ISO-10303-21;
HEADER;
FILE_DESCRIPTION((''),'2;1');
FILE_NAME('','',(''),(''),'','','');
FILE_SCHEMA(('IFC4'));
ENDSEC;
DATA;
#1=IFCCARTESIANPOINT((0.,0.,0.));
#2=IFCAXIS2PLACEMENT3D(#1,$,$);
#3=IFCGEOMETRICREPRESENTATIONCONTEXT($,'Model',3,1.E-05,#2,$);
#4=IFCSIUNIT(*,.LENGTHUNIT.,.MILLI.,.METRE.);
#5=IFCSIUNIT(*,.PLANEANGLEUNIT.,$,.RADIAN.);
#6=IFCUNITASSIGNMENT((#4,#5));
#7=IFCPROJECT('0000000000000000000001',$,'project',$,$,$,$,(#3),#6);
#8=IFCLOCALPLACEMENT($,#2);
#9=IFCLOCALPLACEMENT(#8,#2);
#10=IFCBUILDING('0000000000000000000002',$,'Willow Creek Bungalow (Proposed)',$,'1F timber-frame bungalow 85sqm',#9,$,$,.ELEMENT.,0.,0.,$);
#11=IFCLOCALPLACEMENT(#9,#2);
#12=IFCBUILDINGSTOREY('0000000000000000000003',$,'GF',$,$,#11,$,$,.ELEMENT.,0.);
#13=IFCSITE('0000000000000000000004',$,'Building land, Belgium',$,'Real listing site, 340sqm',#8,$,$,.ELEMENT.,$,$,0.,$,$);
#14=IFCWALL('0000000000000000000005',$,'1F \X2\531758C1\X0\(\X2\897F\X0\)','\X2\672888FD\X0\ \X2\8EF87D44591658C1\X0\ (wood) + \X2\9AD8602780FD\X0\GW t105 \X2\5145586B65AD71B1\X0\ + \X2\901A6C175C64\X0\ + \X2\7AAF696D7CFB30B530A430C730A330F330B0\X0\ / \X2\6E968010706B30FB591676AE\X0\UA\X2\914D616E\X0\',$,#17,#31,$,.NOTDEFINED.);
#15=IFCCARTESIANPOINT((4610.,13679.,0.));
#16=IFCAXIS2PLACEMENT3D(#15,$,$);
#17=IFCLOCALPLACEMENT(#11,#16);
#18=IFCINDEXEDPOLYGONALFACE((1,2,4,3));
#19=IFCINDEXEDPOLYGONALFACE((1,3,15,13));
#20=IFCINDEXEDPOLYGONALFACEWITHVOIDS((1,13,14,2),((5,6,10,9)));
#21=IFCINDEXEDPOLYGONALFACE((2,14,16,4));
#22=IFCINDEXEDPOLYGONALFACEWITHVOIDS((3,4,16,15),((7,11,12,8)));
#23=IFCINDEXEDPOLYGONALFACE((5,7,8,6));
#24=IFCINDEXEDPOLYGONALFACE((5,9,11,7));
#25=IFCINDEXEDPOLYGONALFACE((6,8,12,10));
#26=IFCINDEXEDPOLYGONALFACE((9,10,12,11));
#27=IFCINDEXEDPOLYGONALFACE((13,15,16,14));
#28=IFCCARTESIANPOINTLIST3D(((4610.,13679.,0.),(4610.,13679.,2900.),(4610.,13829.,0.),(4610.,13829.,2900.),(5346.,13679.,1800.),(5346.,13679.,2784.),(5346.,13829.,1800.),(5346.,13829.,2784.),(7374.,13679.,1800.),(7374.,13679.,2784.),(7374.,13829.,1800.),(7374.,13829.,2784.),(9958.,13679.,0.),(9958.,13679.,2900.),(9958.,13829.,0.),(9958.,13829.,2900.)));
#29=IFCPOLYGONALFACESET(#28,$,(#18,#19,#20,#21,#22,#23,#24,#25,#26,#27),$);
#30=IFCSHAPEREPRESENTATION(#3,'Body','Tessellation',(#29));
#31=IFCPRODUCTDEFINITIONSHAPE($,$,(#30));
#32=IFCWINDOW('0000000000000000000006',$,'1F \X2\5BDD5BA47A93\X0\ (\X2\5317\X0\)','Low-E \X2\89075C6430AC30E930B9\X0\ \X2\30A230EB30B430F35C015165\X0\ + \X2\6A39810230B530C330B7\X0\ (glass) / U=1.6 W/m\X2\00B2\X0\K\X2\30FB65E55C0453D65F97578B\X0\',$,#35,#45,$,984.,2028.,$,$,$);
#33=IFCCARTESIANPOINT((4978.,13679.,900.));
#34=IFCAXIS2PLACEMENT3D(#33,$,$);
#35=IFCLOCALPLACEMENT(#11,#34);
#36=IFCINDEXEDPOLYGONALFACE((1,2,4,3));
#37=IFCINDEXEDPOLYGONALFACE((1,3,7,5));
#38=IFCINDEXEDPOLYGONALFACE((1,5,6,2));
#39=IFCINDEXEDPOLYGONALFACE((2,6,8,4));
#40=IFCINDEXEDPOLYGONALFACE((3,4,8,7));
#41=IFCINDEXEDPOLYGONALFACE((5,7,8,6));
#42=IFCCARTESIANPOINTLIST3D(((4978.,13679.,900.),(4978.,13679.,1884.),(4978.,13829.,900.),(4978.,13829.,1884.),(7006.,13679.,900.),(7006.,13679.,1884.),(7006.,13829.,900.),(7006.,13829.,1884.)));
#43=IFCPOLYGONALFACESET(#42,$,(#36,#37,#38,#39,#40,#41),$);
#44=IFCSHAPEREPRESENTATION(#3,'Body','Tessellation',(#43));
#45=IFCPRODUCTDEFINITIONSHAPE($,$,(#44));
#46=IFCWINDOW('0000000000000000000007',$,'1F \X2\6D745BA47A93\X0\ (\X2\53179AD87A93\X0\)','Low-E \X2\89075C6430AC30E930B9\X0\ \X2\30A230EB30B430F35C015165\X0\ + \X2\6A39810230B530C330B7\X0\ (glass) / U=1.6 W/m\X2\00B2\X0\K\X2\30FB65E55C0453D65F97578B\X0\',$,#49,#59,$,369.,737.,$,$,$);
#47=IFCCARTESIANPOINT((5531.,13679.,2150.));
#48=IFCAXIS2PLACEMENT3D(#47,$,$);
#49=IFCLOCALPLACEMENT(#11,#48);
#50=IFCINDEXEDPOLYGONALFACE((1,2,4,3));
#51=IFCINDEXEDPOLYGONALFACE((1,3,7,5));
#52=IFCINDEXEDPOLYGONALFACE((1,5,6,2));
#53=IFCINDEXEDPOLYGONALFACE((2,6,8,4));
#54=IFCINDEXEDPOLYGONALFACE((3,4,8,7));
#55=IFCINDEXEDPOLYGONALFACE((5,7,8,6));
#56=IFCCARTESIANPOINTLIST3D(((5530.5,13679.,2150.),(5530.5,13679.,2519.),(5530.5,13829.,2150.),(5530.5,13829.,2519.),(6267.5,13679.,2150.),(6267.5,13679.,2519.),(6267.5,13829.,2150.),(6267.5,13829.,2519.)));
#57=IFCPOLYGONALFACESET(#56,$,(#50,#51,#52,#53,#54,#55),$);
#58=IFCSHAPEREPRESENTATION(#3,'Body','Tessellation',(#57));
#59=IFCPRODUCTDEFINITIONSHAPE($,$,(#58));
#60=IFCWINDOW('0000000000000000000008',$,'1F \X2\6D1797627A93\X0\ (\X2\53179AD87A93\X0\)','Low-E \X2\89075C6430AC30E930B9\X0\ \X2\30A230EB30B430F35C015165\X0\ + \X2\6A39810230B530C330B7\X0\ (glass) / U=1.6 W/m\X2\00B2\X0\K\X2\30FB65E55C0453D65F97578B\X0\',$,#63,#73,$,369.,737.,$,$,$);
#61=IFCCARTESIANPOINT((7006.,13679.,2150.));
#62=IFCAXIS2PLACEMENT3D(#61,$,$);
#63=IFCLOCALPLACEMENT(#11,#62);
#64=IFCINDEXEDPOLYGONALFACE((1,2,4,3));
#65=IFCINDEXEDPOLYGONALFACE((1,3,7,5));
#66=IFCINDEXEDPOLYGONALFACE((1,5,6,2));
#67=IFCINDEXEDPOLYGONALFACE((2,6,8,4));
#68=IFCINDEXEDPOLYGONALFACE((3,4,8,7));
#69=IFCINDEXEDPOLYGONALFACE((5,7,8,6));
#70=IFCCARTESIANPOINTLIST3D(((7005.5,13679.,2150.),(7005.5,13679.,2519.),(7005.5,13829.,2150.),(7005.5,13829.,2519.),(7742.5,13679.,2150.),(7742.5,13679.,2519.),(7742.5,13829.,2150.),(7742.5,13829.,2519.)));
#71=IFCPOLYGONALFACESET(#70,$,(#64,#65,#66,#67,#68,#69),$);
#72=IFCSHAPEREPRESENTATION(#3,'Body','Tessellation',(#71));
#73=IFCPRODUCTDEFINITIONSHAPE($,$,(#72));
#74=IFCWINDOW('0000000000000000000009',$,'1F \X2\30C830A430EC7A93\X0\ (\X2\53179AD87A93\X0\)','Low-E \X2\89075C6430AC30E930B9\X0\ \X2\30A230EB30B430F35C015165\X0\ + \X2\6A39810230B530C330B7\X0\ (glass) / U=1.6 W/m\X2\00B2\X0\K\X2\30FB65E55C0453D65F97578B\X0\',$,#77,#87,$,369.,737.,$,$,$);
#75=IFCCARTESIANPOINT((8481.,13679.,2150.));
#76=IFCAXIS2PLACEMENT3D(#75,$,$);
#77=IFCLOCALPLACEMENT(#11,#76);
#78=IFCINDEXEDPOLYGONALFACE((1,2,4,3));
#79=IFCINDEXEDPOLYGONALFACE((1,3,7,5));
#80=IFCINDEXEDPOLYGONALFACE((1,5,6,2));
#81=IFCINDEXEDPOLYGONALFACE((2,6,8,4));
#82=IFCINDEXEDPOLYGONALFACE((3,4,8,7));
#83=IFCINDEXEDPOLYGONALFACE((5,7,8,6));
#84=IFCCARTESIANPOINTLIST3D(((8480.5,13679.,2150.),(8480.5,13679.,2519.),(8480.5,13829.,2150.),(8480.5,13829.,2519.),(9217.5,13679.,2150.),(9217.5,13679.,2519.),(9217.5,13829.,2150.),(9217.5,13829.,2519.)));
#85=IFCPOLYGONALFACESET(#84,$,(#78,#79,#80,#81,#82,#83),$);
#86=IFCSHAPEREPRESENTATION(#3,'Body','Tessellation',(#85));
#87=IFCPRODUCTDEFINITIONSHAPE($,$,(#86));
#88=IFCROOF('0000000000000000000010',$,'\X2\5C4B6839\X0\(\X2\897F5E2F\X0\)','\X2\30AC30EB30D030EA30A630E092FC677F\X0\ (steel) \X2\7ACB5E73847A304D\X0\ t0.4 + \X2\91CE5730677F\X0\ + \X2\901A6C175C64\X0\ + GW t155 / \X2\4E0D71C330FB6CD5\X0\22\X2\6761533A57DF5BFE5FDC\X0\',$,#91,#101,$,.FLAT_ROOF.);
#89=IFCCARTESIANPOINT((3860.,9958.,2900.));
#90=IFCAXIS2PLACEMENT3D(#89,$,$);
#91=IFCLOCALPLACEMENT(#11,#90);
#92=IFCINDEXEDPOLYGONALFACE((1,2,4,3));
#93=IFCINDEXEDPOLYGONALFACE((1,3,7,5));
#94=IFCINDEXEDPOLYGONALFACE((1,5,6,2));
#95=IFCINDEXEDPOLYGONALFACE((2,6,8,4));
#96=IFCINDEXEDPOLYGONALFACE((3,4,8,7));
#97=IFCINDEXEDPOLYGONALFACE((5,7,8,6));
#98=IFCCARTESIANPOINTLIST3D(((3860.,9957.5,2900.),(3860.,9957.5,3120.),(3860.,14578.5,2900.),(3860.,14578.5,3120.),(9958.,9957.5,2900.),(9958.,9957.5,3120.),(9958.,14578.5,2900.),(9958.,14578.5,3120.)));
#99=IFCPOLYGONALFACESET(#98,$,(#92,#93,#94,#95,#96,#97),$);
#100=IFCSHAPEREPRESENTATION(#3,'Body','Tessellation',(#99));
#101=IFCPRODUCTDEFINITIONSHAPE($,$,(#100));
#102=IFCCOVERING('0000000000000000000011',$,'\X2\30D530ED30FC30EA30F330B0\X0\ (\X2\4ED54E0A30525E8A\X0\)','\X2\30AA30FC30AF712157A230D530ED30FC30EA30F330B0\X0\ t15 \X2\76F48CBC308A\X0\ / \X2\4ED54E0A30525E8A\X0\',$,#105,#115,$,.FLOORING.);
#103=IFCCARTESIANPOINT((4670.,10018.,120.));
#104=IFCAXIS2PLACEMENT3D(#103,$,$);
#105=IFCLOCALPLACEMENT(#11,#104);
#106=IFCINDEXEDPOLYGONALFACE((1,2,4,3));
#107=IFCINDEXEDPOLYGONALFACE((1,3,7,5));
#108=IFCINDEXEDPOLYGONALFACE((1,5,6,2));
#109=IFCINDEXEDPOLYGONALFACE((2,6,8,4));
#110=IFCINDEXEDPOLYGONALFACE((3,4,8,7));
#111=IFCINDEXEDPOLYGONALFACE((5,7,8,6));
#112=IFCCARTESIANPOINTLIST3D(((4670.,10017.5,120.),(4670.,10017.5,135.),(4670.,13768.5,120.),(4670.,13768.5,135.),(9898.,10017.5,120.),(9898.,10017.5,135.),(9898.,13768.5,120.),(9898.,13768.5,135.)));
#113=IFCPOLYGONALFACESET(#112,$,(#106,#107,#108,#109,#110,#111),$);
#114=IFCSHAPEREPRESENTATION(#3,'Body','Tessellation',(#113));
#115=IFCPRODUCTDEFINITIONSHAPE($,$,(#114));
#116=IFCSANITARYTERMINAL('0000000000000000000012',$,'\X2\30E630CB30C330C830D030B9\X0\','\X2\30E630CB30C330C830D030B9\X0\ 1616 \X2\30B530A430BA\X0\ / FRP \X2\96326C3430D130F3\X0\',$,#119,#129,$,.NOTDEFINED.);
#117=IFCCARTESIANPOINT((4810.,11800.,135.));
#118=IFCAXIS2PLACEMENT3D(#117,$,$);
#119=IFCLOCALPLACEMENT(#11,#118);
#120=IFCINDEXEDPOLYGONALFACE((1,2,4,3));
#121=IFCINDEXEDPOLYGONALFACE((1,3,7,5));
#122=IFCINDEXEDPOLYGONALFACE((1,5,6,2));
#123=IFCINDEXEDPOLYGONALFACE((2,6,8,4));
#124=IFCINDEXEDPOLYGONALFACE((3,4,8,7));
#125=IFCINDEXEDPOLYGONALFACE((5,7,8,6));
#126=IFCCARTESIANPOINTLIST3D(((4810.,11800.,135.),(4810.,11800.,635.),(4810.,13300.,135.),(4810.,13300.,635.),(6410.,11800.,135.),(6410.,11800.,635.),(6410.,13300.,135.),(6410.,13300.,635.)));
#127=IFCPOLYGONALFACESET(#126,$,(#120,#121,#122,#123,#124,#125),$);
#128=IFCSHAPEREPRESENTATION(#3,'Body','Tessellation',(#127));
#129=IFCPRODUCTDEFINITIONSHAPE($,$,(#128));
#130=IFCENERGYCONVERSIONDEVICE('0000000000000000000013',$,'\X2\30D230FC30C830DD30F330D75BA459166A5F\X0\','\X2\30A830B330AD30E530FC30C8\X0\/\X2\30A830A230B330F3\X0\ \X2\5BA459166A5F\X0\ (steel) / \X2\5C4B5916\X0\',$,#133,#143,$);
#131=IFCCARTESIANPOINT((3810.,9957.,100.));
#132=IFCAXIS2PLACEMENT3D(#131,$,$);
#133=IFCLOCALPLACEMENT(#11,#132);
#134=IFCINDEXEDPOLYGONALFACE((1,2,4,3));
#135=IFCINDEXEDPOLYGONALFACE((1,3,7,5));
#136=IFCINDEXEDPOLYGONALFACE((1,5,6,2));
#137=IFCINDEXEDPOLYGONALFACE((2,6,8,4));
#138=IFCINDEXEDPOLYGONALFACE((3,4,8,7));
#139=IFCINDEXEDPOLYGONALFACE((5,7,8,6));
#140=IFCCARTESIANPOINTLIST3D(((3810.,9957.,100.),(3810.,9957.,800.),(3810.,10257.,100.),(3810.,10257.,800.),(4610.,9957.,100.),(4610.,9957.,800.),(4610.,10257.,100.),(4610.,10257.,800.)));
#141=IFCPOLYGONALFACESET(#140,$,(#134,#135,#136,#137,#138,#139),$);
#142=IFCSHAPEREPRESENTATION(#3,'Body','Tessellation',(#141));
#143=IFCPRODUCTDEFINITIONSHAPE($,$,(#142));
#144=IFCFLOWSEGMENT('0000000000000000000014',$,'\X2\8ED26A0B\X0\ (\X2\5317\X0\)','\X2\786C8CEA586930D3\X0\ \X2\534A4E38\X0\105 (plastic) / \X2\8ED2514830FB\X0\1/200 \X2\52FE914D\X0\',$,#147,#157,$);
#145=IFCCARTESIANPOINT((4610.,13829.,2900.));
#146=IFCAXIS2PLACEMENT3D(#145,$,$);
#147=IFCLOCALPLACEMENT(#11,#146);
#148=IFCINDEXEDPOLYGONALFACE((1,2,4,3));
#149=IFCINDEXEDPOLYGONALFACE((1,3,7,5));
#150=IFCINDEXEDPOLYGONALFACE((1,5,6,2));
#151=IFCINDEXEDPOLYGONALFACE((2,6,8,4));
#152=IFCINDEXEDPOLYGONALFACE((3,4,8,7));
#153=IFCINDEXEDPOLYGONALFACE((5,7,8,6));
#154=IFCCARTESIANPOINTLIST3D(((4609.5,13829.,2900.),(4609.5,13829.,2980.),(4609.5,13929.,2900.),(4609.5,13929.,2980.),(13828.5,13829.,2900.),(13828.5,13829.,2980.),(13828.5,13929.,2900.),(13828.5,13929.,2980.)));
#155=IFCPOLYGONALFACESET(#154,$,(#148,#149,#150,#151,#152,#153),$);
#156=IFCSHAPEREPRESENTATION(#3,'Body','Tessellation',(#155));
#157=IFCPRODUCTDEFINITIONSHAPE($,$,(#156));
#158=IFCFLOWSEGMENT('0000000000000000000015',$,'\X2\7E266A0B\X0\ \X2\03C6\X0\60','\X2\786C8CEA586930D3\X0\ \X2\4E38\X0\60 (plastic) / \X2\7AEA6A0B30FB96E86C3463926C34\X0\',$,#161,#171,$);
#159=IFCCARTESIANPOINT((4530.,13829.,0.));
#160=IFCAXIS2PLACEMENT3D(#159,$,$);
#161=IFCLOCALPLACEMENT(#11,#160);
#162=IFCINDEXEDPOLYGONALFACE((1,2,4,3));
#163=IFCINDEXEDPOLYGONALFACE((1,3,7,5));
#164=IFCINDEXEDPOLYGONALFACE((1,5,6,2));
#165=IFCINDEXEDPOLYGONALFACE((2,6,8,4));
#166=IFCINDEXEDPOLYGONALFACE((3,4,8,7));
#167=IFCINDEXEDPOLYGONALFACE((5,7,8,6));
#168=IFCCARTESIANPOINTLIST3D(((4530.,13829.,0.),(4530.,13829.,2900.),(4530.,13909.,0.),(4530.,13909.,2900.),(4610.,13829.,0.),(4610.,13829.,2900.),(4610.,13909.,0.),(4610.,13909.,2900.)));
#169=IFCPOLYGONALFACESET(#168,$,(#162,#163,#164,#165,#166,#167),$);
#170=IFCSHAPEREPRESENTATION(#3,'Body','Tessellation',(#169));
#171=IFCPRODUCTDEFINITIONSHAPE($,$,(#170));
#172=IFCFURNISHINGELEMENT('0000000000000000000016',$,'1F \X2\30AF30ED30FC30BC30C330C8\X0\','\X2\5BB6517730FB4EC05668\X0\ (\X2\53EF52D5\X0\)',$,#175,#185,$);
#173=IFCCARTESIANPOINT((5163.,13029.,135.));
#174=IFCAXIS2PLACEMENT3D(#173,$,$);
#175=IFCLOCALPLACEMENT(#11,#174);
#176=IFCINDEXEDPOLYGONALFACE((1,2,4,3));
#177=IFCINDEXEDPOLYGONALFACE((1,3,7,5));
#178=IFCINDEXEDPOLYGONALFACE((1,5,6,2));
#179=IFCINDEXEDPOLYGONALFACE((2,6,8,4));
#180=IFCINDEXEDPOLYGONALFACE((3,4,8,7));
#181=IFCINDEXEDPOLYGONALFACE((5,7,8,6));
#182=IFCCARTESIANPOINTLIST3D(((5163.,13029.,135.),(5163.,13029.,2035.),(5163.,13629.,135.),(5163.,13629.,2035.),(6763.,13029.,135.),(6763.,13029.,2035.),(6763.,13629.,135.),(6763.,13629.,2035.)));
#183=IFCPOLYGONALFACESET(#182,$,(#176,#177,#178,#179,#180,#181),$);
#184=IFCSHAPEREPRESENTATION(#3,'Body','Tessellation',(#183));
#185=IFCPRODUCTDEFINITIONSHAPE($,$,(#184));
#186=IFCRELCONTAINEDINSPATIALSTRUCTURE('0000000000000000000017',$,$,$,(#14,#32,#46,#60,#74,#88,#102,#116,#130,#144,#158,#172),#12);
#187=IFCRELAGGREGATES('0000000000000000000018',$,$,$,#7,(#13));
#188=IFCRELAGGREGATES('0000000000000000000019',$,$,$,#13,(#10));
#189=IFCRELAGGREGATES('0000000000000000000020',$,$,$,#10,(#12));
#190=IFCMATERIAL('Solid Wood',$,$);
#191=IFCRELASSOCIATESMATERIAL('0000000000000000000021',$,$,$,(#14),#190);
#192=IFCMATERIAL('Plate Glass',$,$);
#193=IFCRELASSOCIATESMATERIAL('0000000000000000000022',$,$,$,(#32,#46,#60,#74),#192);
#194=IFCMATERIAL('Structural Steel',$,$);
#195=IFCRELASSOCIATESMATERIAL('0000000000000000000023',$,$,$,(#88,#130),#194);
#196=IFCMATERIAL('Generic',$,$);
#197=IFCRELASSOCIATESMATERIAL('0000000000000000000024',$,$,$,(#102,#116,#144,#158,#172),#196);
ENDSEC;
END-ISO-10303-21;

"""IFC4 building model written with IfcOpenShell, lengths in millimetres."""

from ifc_helpers import new_model, si_unit, frame, frame_2d, origin, place, context, project, spatial, rectangle, extrude, material, element, fill, save


model = new_model("IFC4")

# Units and contexts
model_context = context("Model", 3, precision=1e-05, world=origin())
ifc_project = project(units=[si_unit("LENGTHUNIT", "METRE", prefix="MILLI"), si_unit("PLANEANGLEUNIT", "RADIAN")], contexts=[model_context])

# Site, building, storey
site_placement = place(None, origin())
site = spatial("IfcSite", under=ifc_project, at=site_placement, Name="Building land, Belgium", ObjectType="Real listing site, 340sqm", CompositionType="ELEMENT", RefElevation=0.0)
building_placement = place(site_placement, origin())
building = spatial("IfcBuilding", under=site, at=building_placement, Name="Willow Creek Bungalow (Proposed)", ObjectType="1F timber-frame bungalow 85sqm", CompositionType="ELEMENT", ElevationOfRefHeight=0.0, ElevationOfTerrain=0.0)
storey_placement = place(building_placement, origin())
storey = spatial("IfcBuildingStorey", under=building, at=storey_placement, Name="GF", CompositionType="ELEMENT", Elevation=0.0)

# Shared definitions
ifc_material_1 = material(Name="Solid Wood")

# Wall, openings, windows
wall_1_placement = place(storey_placement, frame((4610.0, 13679.0, 0.0)))
wall_1 = element("IfcWall", 1, at=wall_1_placement, inside=storey, material=ifc_material_1, Name="1F 北壁(西)", Description="木製 軸組外壁 (wood) + 高性能GW t105 充填断熱 + 通気層 + 窯業系サイディング / 準耐火・外皮UA配慮", PredefinedType="NOTDEFINED", context=model_context, shape_type="SweptSolid", body=[
    extrude(rectangle(XDim=5348.0, YDim=150.0, at=frame_2d((2674.0, 75.0))), frame((4610.0, 13679.0, 0.0)), (0.0, 0.0, 1.0), 2900.0),
])
opening_1_placement = place(storey_placement, frame((4978.0, 13679.0, 900.0)))
opening_1 = element("IfcOpeningElement", 2, at=opening_1_placement, cuts=wall_1, PredefinedType="NOTDEFINED", context=model_context, shape_type="SweptSolid", body=[
    extrude(rectangle(XDim=2028.0, YDim=150.0, at=frame_2d((1014.0, 75.0))), frame((4978.0, 13679.0, 900.0)), (0.0, 0.0, 1.0), 984.0),
])
opening_2_placement = place(storey_placement, frame((5531.0, 13679.0, 2150.0)))
opening_2 = element("IfcOpeningElement", 3, at=opening_2_placement, cuts=wall_1, PredefinedType="NOTDEFINED", context=model_context, shape_type="SweptSolid", body=[
    extrude(rectangle(XDim=737.0, YDim=150.0, at=frame_2d((368.0, 75.0))), frame((5531.0, 13679.0, 2150.0)), (0.0, 0.0, 1.0), 369.0),
])
opening_3_placement = place(storey_placement, frame((7006.0, 13679.0, 2150.0)))
opening_3 = element("IfcOpeningElement", 4, at=opening_3_placement, cuts=wall_1, PredefinedType="NOTDEFINED", context=model_context, shape_type="SweptSolid", body=[
    extrude(rectangle(XDim=737.0, YDim=150.0, at=frame_2d((368.0, 75.0))), frame((7006.0, 13679.0, 2150.0)), (0.0, 0.0, 1.0), 369.0),
])
opening_4_placement = place(storey_placement, frame((8481.0, 13679.0, 2150.0)))
opening_4 = element("IfcOpeningElement", 5, at=opening_4_placement, cuts=wall_1, PredefinedType="NOTDEFINED", context=model_context, shape_type="SweptSolid", body=[
    extrude(rectangle(XDim=737.0, YDim=150.0, at=frame_2d((368.0, 75.0))), frame((8481.0, 13679.0, 2150.0)), (0.0, 0.0, 1.0), 369.0),
])
ifc_material_2 = material(Name="Plate Glass")
window_1_placement = place(storey_placement, frame((4978.0, 13679.0, 900.0)))
window_1 = element("IfcWindow", 6, at=window_1_placement, inside=storey, material=ifc_material_2, Name="1F 寝室窓 (北)", Description="Low-E 複層ガラス アルゴン封入 + 樹脂サッシ (glass) / U=1.6 W/m²K・日射取得型", OverallHeight=984.0, OverallWidth=2028.0, context=model_context, shape_type="SweptSolid", body=[
    extrude(rectangle(XDim=2028.0, YDim=150.0, at=frame_2d((1014.0, 75.0))), frame((4978.0, 13679.0, 900.0)), (0.0, 0.0, 1.0), 984.0),
])
fill(opening_1, window_1)
window_2_placement = place(storey_placement, frame((5531.0, 13679.0, 2150.0)))
window_2 = element("IfcWindow", 7, at=window_2_placement, inside=storey, material=ifc_material_2, Name="1F 浴室窓 (北高窓)", Description="Low-E 複層ガラス アルゴン封入 + 樹脂サッシ (glass) / U=1.6 W/m²K・日射取得型", OverallHeight=369.0, OverallWidth=737.0, context=model_context, shape_type="SweptSolid", body=[
    extrude(rectangle(XDim=737.0, YDim=150.0, at=frame_2d((368.0, 75.0))), frame((5531.0, 13679.0, 2150.0)), (0.0, 0.0, 1.0), 369.0),
])
fill(opening_2, window_2)
window_3_placement = place(storey_placement, frame((7006.0, 13679.0, 2150.0)))
window_3 = element("IfcWindow", 8, at=window_3_placement, inside=storey, material=ifc_material_2, Name="1F 洗面窓 (北高窓)", Description="Low-E 複層ガラス アルゴン封入 + 樹脂サッシ (glass) / U=1.6 W/m²K・日射取得型", OverallHeight=369.0, OverallWidth=737.0, context=model_context, shape_type="SweptSolid", body=[
    extrude(rectangle(XDim=737.0, YDim=150.0, at=frame_2d((368.0, 75.0))), frame((7006.0, 13679.0, 2150.0)), (0.0, 0.0, 1.0), 369.0),
])
fill(opening_3, window_3)
window_4_placement = place(storey_placement, frame((8481.0, 13679.0, 2150.0)))
window_4 = element("IfcWindow", 9, at=window_4_placement, inside=storey, material=ifc_material_2, Name="1F トイレ窓 (北高窓)", Description="Low-E 複層ガラス アルゴン封入 + 樹脂サッシ (glass) / U=1.6 W/m²K・日射取得型", OverallHeight=369.0, OverallWidth=737.0, context=model_context, shape_type="SweptSolid", body=[
    extrude(rectangle(XDim=737.0, YDim=150.0, at=frame_2d((368.0, 75.0))), frame((8481.0, 13679.0, 2150.0)), (0.0, 0.0, 1.0), 369.0),
])
fill(opening_4, window_4)

# Roof
ifc_material_3 = material(Name="Structural Steel")
roof_placement = place(storey_placement, frame((3860.0, 9958.0, 2900.0)))
element("IfcRoof", 10, at=roof_placement, inside=storey, material=ifc_material_3, Name="屋根(西帯)", Description="ガルバリウム鋼板 (steel) 立平葺き t0.4 + 野地板 + 通気層 + GW t155 / 不燃・法22条区域対応", PredefinedType="FLAT_ROOF", context=model_context, shape_type="SweptSolid", body=[
    extrude(rectangle(XDim=6098.0, YDim=4621.0, at=frame_2d((3049.0, 2310.0))), frame((3860.0, 9958.0, 2900.0)), (0.0, 0.0, 1.0), 220.0),
])

# Covering
ifc_material_4 = material(Name="Generic")
covering_placement = place(storey_placement, frame((4670.0, 10018.0, 120.0)))
element("IfcCovering", 11, at=covering_placement, inside=storey, material=ifc_material_4, Name="フローリング (仕上げ床)", Description="オーク無垢フローリング t15 直貼り / 仕上げ床", PredefinedType="FLOORING", context=model_context, shape_type="SweptSolid", body=[
    extrude(rectangle(XDim=5228.0, YDim=3751.0, at=frame_2d((2614.0, 1875.0))), frame((4670.0, 10018.0, 120.0)), (0.0, 0.0, 1.0), 15.0),
])

# Sanitary terminal
sanitary_terminal_placement = place(storey_placement, frame((4810.0, 11800.0, 135.0)))
element("IfcSanitaryTerminal", 12, at=sanitary_terminal_placement, inside=storey, material=ifc_material_4, Name="ユニットバス", Description="ユニットバス 1616 サイズ / FRP 防水パン", PredefinedType="NOTDEFINED", context=model_context, shape_type="SweptSolid", body=[
    extrude(rectangle(XDim=1600.0, YDim=1500.0, at=frame_2d((800.0, 750.0))), frame((4810.0, 11800.0, 135.0)), (0.0, 0.0, 1.0), 500.0),
])

# Energy conversion device
energy_conversion_device_placement = place(storey_placement, frame((3810.0, 9957.0, 100.0)))
element("IfcEnergyConversionDevice", 13, at=energy_conversion_device_placement, inside=storey, material=ifc_material_3, Name="ヒートポンプ室外機", Description="エコキュート/エアコン 室外機 (steel) / 屋外", context=model_context, shape_type="SweptSolid", body=[
    extrude(rectangle(XDim=800.0, YDim=300.0, at=frame_2d((400.0, 150.0))), frame((3810.0, 9957.0, 100.0)), (0.0, 0.0, 1.0), 700.0),
])

# Flow segments
flow_segment_1_placement = place(storey_placement, frame((4610.0, 13829.0, 2900.0)))
element("IfcFlowSegment", 14, at=flow_segment_1_placement, inside=storey, material=ifc_material_4, Name="軒樋 (北)", Description="硬質塩ビ 半丸105 (plastic) / 軒先・1/200 勾配", context=model_context, shape_type="SweptSolid", body=[
    extrude(rectangle(XDim=9219.0, YDim=100.0, at=frame_2d((4609.0, 50.0))), frame((4610.0, 13829.0, 2900.0)), (0.0, 0.0, 1.0), 80.0),
])
flow_segment_2_placement = place(storey_placement, frame((4530.0, 13829.0, 0.0)))
element("IfcFlowSegment", 15, at=flow_segment_2_placement, inside=storey, material=ifc_material_4, Name="縦樋 φ60", Description="硬質塩ビ 丸60 (plastic) / 竪樋・雨水排水", context=model_context, shape_type="SweptSolid", body=[
    extrude(rectangle(XDim=80.0, YDim=80.0, at=frame_2d((40.0, 40.0))), frame((4530.0, 13829.0, 0.0)), (0.0, 0.0, 1.0), 2900.0),
])

# Furnishing element
furnishing_1_placement = place(storey_placement, frame((5163.0, 13029.0, 135.0)))
element("IfcFurnishingElement", 16, at=furnishing_1_placement, inside=storey, material=ifc_material_4, Name="1F クローゼット", Description="家具・什器 (可動)", context=model_context, shape_type="SweptSolid", body=[
    extrude(rectangle(XDim=1600.0, YDim=600.0, at=frame_2d((800.0, 300.0))), frame((5163.0, 13029.0, 135.0)), (0.0, 0.0, 1.0), 1900.0),
])

save(model, "model.ifc")
